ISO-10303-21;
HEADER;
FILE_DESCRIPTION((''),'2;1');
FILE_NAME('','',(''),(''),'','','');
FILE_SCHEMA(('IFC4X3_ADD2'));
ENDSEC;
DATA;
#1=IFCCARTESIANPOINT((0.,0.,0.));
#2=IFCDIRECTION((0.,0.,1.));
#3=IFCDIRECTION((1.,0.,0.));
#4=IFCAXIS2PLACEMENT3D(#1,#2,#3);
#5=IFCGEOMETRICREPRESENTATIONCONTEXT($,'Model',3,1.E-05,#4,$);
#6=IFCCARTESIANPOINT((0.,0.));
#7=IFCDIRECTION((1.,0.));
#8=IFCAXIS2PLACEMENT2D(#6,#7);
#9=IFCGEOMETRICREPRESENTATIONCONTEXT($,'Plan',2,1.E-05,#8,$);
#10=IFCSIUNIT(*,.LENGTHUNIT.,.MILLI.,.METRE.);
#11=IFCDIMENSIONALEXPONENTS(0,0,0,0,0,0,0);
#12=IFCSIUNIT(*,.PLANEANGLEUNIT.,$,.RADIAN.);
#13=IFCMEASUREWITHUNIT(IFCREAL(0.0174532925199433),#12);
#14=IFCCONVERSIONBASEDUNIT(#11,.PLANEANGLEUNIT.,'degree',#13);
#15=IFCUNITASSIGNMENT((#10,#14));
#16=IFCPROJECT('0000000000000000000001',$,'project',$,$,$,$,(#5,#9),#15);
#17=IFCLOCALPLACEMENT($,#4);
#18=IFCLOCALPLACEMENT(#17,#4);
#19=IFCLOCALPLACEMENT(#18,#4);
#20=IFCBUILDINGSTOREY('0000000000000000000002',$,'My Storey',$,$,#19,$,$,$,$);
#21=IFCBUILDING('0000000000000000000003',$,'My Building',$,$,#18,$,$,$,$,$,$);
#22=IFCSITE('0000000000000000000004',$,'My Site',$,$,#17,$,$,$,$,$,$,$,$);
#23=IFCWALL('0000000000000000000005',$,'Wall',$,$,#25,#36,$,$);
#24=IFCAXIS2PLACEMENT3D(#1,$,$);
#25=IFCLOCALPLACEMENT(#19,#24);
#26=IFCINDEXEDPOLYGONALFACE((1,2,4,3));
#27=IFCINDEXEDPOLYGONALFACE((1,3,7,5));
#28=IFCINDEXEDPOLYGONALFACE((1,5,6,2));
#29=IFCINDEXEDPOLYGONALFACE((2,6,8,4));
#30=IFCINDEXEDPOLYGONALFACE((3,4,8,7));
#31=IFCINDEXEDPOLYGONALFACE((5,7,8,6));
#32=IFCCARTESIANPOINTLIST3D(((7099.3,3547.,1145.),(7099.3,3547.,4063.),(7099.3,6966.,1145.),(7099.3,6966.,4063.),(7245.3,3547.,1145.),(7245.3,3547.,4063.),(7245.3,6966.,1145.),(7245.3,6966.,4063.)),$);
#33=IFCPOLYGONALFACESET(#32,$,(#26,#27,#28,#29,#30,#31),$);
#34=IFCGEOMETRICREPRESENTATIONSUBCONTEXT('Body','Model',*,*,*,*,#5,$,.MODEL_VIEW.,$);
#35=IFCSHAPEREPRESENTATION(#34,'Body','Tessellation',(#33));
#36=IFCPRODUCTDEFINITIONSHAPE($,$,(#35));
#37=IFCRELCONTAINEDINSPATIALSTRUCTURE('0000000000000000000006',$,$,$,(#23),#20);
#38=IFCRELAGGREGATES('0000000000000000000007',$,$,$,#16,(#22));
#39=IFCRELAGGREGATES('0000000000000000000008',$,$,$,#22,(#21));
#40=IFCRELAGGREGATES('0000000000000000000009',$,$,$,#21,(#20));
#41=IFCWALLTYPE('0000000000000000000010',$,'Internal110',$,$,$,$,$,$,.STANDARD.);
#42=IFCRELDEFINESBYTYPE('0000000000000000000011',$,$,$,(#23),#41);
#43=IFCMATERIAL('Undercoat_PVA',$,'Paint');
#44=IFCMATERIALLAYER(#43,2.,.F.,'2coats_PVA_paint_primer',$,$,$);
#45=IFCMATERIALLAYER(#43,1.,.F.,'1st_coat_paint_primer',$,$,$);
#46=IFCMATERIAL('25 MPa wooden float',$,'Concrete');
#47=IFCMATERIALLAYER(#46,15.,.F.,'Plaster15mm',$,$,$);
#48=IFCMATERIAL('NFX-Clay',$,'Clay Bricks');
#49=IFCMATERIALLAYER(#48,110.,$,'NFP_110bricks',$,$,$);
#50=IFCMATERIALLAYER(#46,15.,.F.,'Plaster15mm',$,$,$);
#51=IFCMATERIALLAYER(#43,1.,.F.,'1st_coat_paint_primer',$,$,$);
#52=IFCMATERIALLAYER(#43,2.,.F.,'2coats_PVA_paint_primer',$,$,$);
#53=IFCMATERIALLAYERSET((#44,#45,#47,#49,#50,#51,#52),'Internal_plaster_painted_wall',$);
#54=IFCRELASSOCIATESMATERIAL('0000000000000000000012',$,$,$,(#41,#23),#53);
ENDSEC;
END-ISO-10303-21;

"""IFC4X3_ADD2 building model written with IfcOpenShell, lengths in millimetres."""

from ifc_helpers import new_model, entity, si_unit, converted_unit, frame, origin_with_axes, origin_2d_with_axis, place, context, subcontext, project, spatial, line, indexed_curve, outline, extrude, material, layer, layer_set, layer_usage, type_object, element, save


model = new_model("IFC4X3_ADD2")

# Units and contexts
model_context = context("Model", 3, precision=1e-05, world=origin_with_axes())
plan_context = context("Plan", 2, precision=1e-05, world=origin_2d_with_axis())
body_context_1 = subcontext(model_context, "Body", "Model", "MODEL_VIEW")
ifc_project = project(units=[si_unit("LENGTHUNIT", "METRE", prefix="MILLI"), converted_unit("PLANEANGLEUNIT", "degree", entity("IfcReal", 0.0174532925199433), si_unit("PLANEANGLEUNIT", "RADIAN"), dimensions=[0, 0, 0, 0, 0, 0, 0])], contexts=[model_context, plan_context])

# Site, building, storey
site_placement = place(None, origin_with_axes())
site = spatial("IfcSite", under=ifc_project, at=site_placement, Name="My Site")
building_placement = place(site_placement, origin_with_axes())
building = spatial("IfcBuilding", under=site, at=building_placement, Name="My Building")
storey_placement = place(building_placement, origin_with_axes())
storey = spatial("IfcBuildingStorey", under=building, at=storey_placement, Name="My Storey")

# Shared definitions
ifc_material_1 = material(Name="25 MPa wooden float", Category="Concrete")

# Wall
ifc_material_2 = material(Name="Undercoat_PVA", Category="Paint")
ifc_layer_1 = layer(ifc_material_2, 2.0, ventilated=False, Name="2coats_PVA_paint_primer")
ifc_layer_2 = layer(ifc_material_2, 1.0, ventilated=False, Name="1st_coat_paint_primer")
ifc_layer_3 = layer(ifc_material_1, 15.0, ventilated=False, Name="Plaster15mm")
ifc_material_3 = material(Name="NFX-Clay", Category="Clay Bricks")
ifc_layer_4 = layer(ifc_material_3, 110.0, Name="NFP_110bricks")
ifc_layer_5 = layer(ifc_material_1, 15.0, ventilated=False, Name="Plaster15mm")
ifc_layer_6 = layer(ifc_material_2, 1.0, ventilated=False, Name="1st_coat_paint_primer")
ifc_layer_7 = layer(ifc_material_2, 2.0, ventilated=False, Name="2coats_PVA_paint_primer")
ifc_layer_set_1 = layer_set([ifc_layer_1, ifc_layer_2, ifc_layer_3, ifc_layer_4, ifc_layer_5, ifc_layer_6, ifc_layer_7], Name="Internal_plaster_painted_wall")
ifc_layer_usage_1 = layer_usage(ifc_layer_set_1, "AXIS2", "POSITIVE", 0.0)
wall_type_1 = type_object("IfcWallType", Name="Internal110", PredefinedType="STANDARD", material=ifc_layer_set_1)
wall_1_placement = place(storey_placement, frame((7099.3, 6966.0, 1145.0), z_axis=(0.0, 0.0, 1.0), x_axis=(0.0, -1.0, 0.0)))
element("IfcWall", 1, at=wall_1_placement, inside=storey, type_object=wall_type_1, material=ifc_layer_usage_1, Name="Wall", context=body_context_1, shape_type="SweptSolid", body=[
    extrude(outline(indexed_curve([(0.0, 0.0), (0.0, 146.0), (3419.0, 146.0), (3419.0, 0.0)], segments=[line(1, 2, 3, 4, 1)])), origin_with_axes(), (0.0, 0.0, 1.0), 2918.0),
])

save(model, "model.ifc")
